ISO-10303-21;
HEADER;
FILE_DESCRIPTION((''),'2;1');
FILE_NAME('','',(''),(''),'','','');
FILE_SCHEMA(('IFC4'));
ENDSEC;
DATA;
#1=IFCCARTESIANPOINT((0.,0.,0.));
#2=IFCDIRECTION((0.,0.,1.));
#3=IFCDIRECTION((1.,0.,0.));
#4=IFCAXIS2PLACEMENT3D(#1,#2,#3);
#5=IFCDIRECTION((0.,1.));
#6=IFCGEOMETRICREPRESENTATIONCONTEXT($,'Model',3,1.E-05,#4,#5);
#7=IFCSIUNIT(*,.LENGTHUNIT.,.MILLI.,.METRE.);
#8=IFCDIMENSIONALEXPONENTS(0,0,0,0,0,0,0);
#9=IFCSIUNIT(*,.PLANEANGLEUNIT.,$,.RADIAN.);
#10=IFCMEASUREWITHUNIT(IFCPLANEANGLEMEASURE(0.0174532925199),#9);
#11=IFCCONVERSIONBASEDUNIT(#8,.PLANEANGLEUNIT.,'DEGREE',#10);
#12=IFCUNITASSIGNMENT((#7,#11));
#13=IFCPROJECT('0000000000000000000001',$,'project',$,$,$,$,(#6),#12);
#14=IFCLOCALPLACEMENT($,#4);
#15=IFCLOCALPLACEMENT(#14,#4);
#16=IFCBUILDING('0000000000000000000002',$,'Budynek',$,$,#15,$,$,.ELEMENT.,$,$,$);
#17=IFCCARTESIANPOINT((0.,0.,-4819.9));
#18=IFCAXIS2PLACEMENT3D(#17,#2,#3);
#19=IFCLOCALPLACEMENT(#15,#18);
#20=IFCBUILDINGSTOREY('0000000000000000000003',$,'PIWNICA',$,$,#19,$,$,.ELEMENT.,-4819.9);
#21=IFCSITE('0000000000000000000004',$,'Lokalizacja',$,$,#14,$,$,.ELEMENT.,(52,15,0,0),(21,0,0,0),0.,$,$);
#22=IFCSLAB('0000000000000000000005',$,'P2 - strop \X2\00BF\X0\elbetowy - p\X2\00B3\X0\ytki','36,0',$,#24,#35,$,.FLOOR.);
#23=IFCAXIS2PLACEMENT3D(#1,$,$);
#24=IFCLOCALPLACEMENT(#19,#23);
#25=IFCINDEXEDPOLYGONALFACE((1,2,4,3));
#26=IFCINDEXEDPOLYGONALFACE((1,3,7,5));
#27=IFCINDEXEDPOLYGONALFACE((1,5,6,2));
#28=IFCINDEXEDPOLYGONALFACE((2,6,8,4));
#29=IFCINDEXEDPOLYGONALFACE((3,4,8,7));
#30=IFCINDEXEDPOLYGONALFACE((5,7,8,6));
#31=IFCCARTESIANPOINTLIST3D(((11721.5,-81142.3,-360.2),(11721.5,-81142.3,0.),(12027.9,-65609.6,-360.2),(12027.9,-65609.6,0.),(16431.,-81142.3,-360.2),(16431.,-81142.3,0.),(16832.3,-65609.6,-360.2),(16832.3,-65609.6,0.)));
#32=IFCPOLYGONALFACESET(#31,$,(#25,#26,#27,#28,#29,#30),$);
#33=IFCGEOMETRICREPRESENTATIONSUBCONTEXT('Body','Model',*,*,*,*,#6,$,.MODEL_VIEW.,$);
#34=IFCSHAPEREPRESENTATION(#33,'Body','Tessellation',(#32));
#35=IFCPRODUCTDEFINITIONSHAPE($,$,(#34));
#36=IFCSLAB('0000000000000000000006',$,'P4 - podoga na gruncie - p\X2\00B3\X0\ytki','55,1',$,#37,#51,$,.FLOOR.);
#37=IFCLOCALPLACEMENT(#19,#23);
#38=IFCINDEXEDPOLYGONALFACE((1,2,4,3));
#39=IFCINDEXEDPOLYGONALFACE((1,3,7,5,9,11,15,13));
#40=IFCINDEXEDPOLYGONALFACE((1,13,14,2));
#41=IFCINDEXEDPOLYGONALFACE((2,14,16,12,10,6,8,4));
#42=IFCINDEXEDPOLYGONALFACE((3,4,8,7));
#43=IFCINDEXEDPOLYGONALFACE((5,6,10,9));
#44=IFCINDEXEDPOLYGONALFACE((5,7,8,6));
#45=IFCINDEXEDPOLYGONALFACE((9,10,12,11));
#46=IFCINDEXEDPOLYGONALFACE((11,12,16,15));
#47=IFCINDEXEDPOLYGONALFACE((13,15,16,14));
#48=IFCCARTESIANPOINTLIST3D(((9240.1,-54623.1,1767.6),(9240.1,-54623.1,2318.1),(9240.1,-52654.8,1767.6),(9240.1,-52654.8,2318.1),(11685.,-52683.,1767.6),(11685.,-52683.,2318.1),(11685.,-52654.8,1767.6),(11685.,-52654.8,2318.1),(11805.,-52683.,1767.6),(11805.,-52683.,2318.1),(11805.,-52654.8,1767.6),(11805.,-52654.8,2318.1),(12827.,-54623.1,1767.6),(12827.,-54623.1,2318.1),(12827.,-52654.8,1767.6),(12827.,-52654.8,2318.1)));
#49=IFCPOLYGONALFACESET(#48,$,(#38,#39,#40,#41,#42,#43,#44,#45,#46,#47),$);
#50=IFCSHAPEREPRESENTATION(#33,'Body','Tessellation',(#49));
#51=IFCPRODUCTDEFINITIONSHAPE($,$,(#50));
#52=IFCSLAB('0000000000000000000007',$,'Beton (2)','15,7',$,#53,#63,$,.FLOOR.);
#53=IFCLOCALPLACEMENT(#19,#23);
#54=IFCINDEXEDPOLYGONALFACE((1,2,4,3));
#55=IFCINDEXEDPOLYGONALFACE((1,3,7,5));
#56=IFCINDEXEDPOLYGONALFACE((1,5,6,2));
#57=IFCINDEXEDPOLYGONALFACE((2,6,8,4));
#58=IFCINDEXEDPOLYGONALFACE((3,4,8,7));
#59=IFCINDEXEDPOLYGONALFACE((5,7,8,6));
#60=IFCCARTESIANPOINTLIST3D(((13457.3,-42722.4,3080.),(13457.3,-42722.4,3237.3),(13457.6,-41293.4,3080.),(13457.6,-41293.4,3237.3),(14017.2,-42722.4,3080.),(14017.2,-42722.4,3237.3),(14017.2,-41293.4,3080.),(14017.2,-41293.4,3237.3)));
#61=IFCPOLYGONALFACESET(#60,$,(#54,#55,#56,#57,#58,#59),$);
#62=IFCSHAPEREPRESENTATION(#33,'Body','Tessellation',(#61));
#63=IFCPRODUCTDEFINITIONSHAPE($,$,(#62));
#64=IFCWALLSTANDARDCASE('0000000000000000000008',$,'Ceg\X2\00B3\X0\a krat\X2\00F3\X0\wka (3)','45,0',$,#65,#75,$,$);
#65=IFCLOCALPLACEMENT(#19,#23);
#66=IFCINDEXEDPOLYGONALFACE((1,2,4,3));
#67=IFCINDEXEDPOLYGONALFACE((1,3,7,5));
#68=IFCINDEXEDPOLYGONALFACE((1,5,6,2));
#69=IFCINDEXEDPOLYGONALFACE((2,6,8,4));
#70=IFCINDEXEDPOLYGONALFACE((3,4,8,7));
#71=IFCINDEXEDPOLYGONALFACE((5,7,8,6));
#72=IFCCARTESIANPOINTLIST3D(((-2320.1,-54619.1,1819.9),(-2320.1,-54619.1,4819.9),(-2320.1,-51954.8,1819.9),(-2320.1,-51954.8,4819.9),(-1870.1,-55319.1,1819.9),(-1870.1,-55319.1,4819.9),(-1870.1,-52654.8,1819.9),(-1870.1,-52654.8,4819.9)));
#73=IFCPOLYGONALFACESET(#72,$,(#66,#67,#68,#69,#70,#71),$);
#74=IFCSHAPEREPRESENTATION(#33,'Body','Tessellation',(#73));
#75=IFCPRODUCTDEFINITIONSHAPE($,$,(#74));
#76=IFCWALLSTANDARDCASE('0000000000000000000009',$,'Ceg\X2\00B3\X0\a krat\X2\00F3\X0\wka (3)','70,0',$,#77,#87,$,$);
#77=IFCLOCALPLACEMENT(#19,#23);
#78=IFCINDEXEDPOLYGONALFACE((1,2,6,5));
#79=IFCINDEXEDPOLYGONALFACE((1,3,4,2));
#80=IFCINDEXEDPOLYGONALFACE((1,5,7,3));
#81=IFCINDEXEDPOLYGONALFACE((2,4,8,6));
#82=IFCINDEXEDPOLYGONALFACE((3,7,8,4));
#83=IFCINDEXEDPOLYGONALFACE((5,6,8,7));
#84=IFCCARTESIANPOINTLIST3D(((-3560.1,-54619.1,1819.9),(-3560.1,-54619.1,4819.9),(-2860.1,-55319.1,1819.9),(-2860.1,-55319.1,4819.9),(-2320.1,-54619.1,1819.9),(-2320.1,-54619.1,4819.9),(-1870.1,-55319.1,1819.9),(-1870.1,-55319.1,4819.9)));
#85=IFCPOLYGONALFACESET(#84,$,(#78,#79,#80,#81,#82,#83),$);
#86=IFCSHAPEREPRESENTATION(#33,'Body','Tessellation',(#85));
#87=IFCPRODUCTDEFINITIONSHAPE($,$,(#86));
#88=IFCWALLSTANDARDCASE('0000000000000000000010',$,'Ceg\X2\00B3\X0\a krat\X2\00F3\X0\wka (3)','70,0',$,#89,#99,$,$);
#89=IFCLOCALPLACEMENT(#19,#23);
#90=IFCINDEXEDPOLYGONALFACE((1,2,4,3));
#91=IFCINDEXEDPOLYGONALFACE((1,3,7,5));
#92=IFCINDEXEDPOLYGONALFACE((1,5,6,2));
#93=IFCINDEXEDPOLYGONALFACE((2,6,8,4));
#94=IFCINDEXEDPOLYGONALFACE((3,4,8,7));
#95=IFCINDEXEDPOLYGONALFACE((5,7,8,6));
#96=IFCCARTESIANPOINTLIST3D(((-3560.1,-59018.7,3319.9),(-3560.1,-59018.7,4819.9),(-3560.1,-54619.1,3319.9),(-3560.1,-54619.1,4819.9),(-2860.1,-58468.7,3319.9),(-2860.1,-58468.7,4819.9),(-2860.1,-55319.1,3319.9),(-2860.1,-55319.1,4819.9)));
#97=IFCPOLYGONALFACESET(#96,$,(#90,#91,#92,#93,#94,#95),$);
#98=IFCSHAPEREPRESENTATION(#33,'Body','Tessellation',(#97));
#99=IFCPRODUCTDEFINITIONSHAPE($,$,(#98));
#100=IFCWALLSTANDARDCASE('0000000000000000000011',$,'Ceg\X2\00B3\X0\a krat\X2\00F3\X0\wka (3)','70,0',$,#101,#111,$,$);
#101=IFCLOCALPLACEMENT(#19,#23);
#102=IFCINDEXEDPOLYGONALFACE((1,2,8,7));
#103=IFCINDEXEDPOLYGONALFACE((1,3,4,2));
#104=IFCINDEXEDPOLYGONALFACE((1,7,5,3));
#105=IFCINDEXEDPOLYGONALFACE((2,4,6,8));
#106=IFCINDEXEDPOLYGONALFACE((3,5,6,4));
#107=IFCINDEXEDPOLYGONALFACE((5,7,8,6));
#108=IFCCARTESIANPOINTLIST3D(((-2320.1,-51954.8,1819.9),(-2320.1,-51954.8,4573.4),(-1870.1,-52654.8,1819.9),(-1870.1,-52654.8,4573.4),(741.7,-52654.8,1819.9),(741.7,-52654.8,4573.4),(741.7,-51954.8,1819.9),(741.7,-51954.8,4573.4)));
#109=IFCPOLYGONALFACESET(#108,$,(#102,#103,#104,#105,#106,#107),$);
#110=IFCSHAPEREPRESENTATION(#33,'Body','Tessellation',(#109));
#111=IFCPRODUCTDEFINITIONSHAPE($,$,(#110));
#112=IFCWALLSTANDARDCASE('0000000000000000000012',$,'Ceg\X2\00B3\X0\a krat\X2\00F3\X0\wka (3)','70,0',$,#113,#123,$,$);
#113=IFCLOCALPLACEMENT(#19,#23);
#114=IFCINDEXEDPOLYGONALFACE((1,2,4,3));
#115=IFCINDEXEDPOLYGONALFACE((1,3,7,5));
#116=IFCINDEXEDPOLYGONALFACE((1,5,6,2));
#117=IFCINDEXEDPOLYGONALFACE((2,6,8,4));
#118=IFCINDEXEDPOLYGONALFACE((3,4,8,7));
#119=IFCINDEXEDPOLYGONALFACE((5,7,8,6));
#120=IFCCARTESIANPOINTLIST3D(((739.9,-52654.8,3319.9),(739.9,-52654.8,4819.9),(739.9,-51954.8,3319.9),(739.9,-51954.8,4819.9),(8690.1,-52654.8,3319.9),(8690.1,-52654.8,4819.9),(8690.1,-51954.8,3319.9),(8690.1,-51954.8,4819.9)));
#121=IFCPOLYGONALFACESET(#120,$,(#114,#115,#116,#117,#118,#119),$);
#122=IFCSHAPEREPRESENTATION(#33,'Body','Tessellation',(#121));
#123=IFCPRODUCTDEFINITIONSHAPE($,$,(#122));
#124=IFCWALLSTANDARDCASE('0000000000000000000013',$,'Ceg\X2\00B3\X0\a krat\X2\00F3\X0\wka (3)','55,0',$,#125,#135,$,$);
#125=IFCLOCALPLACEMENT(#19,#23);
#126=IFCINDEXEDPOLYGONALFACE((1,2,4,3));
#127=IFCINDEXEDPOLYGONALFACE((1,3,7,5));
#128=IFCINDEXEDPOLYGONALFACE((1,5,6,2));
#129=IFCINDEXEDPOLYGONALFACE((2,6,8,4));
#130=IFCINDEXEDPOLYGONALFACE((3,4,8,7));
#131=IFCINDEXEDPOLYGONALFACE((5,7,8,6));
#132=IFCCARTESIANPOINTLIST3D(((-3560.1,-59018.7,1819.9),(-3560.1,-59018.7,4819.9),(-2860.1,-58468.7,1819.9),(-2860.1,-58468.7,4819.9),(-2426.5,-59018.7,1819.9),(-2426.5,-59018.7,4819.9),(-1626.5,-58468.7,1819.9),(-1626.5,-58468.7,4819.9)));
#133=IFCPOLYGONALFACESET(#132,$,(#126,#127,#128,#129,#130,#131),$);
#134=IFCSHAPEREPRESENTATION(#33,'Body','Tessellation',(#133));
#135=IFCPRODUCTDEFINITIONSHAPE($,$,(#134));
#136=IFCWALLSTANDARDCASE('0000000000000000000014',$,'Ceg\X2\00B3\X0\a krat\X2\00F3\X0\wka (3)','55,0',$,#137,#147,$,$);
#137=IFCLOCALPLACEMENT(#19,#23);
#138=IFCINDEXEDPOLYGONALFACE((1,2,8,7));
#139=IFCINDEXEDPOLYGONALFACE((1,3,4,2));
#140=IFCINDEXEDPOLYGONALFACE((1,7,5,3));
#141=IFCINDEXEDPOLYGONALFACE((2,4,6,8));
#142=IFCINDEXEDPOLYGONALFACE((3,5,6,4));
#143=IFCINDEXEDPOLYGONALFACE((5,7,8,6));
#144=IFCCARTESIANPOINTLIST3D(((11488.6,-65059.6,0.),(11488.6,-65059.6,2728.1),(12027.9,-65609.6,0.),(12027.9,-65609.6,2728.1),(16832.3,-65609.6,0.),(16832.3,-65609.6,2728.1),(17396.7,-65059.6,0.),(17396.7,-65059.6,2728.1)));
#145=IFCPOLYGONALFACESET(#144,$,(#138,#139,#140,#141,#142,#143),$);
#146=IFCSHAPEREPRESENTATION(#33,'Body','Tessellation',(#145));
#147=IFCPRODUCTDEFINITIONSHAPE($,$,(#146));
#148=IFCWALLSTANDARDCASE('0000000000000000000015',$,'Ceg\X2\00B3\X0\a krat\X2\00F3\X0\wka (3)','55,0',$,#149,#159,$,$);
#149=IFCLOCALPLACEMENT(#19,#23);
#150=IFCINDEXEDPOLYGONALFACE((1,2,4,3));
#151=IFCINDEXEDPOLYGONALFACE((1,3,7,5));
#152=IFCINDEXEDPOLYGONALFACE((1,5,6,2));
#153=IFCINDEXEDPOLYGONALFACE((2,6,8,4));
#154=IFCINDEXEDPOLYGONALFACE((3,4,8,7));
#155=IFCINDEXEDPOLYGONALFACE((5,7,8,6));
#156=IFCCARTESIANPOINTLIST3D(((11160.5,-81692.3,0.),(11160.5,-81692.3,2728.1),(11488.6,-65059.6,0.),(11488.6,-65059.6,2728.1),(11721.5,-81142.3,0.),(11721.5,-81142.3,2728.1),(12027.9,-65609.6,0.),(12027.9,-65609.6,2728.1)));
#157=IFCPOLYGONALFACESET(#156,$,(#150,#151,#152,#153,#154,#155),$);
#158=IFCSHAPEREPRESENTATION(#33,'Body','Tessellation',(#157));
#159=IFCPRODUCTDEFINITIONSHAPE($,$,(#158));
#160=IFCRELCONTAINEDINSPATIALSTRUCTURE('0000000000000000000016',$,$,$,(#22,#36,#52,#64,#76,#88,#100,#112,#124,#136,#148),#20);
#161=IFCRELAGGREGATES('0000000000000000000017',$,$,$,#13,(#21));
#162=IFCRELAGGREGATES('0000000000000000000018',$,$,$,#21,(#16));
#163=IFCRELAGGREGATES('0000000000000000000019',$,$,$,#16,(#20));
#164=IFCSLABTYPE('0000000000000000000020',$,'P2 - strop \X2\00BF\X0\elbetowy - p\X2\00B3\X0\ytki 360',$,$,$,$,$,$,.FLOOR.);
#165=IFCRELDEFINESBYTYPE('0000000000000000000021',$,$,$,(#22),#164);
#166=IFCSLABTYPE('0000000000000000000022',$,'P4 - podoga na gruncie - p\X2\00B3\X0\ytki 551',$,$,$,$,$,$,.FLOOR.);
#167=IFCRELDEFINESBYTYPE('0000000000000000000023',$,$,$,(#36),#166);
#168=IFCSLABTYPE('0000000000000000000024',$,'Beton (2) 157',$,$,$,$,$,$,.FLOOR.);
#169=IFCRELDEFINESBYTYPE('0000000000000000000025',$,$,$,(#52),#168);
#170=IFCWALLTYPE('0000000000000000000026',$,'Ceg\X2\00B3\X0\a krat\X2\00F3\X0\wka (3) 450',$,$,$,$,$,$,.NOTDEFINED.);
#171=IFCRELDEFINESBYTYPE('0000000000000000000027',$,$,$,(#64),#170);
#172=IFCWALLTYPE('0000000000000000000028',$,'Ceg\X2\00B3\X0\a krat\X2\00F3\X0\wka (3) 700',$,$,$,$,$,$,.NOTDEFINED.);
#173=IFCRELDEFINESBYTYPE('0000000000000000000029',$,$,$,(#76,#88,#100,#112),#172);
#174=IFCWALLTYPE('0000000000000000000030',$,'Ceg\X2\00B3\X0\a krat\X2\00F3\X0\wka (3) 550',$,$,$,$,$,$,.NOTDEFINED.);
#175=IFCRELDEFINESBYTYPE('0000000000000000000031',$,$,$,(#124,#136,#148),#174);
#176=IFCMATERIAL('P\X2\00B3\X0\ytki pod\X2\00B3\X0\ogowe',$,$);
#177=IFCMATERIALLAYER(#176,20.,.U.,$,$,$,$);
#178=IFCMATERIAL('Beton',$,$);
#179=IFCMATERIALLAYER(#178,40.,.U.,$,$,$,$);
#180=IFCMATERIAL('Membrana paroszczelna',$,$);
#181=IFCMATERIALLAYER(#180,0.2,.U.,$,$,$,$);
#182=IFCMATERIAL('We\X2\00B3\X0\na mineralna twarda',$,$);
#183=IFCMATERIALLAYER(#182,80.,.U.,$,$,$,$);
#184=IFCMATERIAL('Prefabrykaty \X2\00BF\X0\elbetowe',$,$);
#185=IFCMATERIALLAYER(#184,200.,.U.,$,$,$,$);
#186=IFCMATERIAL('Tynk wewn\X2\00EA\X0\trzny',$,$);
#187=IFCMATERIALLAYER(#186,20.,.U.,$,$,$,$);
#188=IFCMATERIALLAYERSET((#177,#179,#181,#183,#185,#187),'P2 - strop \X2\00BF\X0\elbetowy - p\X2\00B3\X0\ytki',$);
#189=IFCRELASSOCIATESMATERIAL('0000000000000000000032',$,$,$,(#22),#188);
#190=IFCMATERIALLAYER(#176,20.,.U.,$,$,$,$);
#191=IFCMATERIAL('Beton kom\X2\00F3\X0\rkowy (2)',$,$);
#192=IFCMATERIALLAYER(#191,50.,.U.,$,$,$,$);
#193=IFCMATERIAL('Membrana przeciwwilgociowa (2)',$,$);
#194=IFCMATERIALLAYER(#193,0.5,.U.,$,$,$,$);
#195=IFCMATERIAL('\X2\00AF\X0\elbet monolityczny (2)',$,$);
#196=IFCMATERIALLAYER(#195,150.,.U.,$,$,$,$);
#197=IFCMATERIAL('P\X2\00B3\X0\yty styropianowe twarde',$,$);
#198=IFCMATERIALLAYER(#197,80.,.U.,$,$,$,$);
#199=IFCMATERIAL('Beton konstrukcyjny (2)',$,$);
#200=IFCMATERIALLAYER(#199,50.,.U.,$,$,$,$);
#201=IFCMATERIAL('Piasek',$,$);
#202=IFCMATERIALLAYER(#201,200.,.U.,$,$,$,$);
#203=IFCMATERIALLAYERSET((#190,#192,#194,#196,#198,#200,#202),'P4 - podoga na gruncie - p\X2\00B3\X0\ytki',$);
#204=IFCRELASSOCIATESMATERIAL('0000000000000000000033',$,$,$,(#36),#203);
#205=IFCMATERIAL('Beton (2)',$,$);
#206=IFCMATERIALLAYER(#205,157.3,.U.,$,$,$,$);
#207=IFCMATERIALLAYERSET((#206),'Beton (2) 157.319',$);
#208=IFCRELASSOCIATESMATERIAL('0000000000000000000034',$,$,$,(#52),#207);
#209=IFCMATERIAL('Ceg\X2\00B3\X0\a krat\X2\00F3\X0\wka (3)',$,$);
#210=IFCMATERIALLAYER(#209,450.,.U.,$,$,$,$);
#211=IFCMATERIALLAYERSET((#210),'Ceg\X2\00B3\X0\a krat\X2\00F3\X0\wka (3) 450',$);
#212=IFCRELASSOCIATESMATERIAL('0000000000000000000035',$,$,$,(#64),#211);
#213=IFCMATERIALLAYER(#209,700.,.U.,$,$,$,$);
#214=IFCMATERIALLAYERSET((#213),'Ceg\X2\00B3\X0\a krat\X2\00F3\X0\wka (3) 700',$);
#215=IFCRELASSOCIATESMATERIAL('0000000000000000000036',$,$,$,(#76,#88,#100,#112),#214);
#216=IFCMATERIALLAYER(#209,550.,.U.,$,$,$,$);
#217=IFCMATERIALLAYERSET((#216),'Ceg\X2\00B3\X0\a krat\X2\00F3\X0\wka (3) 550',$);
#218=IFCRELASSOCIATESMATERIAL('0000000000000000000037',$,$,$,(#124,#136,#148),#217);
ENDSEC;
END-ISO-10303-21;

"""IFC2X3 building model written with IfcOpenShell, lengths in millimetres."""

from ifc_helpers import new_model, entity, si_unit, converted_unit, direction, frame, origin_with_axes, place, context, subcontext, project, spatial, polyline, outline, extrude, material, layer, layer_set, layer_usage, type_object, element, save


model = new_model("IFC2X3")

# Units and contexts
model_context = context("Model", 3, precision=1e-05, world=origin_with_axes(), true_north=direction((0.0, 1.0)))
body_context = subcontext(model_context, "Body", "Model", "MODEL_VIEW")
ifc_project = project(units=[si_unit("LENGTHUNIT", "METRE", prefix="MILLI"), converted_unit("PLANEANGLEUNIT", "DEGREE", entity("IfcPlaneAngleMeasure", 0.0174532925199), si_unit("PLANEANGLEUNIT", "RADIAN"), dimensions=[0, 0, 0, 0, 0, 0, 0])], contexts=[model_context])

# Site, building, storey
site_placement = place(None, origin_with_axes())
site = spatial("IfcSite", under=ifc_project, at=site_placement, Name="Lokalizacja", CompositionType="ELEMENT", RefLatitude=(52, 15, 0, 0), RefLongitude=(21, 0, 0, 0), RefElevation=0.0)
building_placement = place(site_placement, origin_with_axes())
building = spatial("IfcBuilding", under=site, at=building_placement, Name="Budynek", CompositionType="ELEMENT")
storey_placement = place(building_placement, frame((0.0, 0.0, -4819.9), z_axis=(0.0, 0.0, 1.0), x_axis=(1.0, 0.0, 0.0)))
storey = spatial("IfcBuildingStorey", under=building, at=storey_placement, Name="PIWNICA", CompositionType="ELEMENT", Elevation=-4819.9)

# Slabs
ifc_material_1 = material(Name="P³ytki pod³ogowe")
ifc_layer_1 = layer(ifc_material_1, 20.0, ventilated="UNKNOWN")
ifc_material_2 = material(Name="Beton")
ifc_layer_2 = layer(ifc_material_2, 40.0, ventilated="UNKNOWN")
ifc_material_3 = material(Name="Membrana paroszczelna")
ifc_layer_3 = layer(ifc_material_3, 0.2, ventilated="UNKNOWN")
ifc_material_4 = material(Name="We³na mineralna twarda")
ifc_layer_4 = layer(ifc_material_4, 80.0, ventilated="UNKNOWN")
ifc_material_5 = material(Name="Prefabrykaty ¿elbetowe")
ifc_layer_5 = layer(ifc_material_5, 200.0, ventilated="UNKNOWN")
ifc_material_6 = material(Name="Tynk wewnêtrzny")
ifc_layer_6 = layer(ifc_material_6, 20.0, ventilated="UNKNOWN")
ifc_layer_set_1 = layer_set([ifc_layer_1, ifc_layer_2, ifc_layer_3, ifc_layer_4, ifc_layer_5, ifc_layer_6], Name="P2 - strop ¿elbetowy - p³ytki")
ifc_layer_usage_1 = layer_usage(ifc_layer_set_1, "AXIS3", "NEGATIVE", 360.2)
slab_type_1 = type_object("IfcSlabType", Name="P2 - strop ¿elbetowy - p³ytki 360", PredefinedType="FLOOR")
slab_1_placement = place(storey_placement, frame((12027.9, -65609.6, 0.0), z_axis=(0.0, 0.0, 1.0), x_axis=(1.0, 0.0, 0.0)))
element("IfcSlab", 1, at=slab_1_placement, inside=storey, type_object=slab_type_1, material=ifc_layer_usage_1, Name="P2 - strop ¿elbetowy - p³ytki", Description="36,0", PredefinedType="FLOOR", context=body_context, shape_type="SweptSolid", body=[
    extrude(outline(polyline([(0.0, 0.0), (-306.4, -15532.7), (4403.1, -15532.7), (4804.4, 0.0), (0.0, 0.0)])), frame((0.0, 0.0, -360.2), z_axis=(0.0, 0.0, 1.0), x_axis=(1.0, 0.0, 0.0)), (0.0, 0.0, 1.0), 360.2),
])
ifc_layer_7 = layer(ifc_material_1, 20.0, ventilated="UNKNOWN")
ifc_material_7 = material(Name="Beton komórkowy (2)")
ifc_layer_8 = layer(ifc_material_7, 50.0, ventilated="UNKNOWN")
ifc_material_8 = material(Name="Membrana przeciwwilgociowa (2)")
ifc_layer_9 = layer(ifc_material_8, 0.5, ventilated="UNKNOWN")
ifc_material_9 = material(Name="¯elbet monolityczny (2)")
ifc_layer_10 = layer(ifc_material_9, 150.0, ventilated="UNKNOWN")
ifc_material_10 = material(Name="P³yty styropianowe twarde")
ifc_layer_11 = layer(ifc_material_10, 80.0, ventilated="UNKNOWN")
ifc_material_11 = material(Name="Beton konstrukcyjny (2)")
ifc_layer_12 = layer(ifc_material_11, 50.0, ventilated="UNKNOWN")
ifc_material_12 = material(Name="Piasek")
ifc_layer_13 = layer(ifc_material_12, 200.0, ventilated="UNKNOWN")
ifc_layer_set_2 = layer_set([ifc_layer_7, ifc_layer_8, ifc_layer_9, ifc_layer_10, ifc_layer_11, ifc_layer_12, ifc_layer_13], Name="P4 - podoga na gruncie - p³ytki")
ifc_layer_usage_2 = layer_usage(ifc_layer_set_2, "AXIS3", "NEGATIVE", 550.5)
slab_type_2 = type_object("IfcSlabType", Name="P4 - podoga na gruncie - p³ytki 551", PredefinedType="FLOOR")
slab_2_placement = place(storey_placement, frame((9240.1, -52654.8, 2318.1), z_axis=(0.0, 0.0, 1.0), x_axis=(1.0, 0.0, 0.0)))
element("IfcSlab", 2, at=slab_2_placement, inside=storey, type_object=slab_type_2, material=ifc_layer_usage_2, Name="P4 - podoga na gruncie - p³ytki", Description="55,1", PredefinedType="FLOOR", context=body_context, shape_type="SweptSolid", body=[
    extrude(outline(polyline([(0.0, 0.0), (0.0, -1968.3), (3586.9, -1968.3), (3586.9, 0.0), (2564.9, 0.0), (2564.9, -28.2), (2444.9, -28.2), (2444.9, 0.0), (0.0, 0.0)])), frame((0.0, 0.0, -550.5), z_axis=(0.0, 0.0, 1.0), x_axis=(1.0, 0.0, 0.0)), (0.0, 0.0, 1.0), 550.5),
])
ifc_material_13 = material(Name="Beton (2)")
ifc_layer_14 = layer(ifc_material_13, 157.3, ventilated="UNKNOWN")
ifc_layer_set_3 = layer_set([ifc_layer_14], Name="Beton (2) 157.319")
ifc_layer_usage_3 = layer_usage(ifc_layer_set_3, "AXIS3", "NEGATIVE", 157.3)
slab_type_3 = type_object("IfcSlabType", Name="Beton (2) 157", PredefinedType="FLOOR")
slab_3_placement = place(storey_placement, frame((13457.6, -41293.4, 3237.3), z_axis=(0.0, 0.0, 1.0), x_axis=(1.0, 0.0, 0.0)))
element("IfcSlab", 3, at=slab_3_placement, inside=storey, type_object=slab_type_3, material=ifc_layer_usage_3, Name="Beton (2)", Description="15,7", PredefinedType="FLOOR", context=body_context, shape_type="SweptSolid", body=[
    extrude(outline(polyline([(0.0, 0.0), (-0.3, -1429.0), (559.6, -1429.0), (559.6, 0.0), (0.0, 0.0)])), frame((0.0, 0.0, -157.3), z_axis=(0.0, 0.0, 1.0), x_axis=(1.0, 0.0, 0.0)), (0.0, 0.0, 1.0), 157.3),
])

# Walls
ifc_material_14 = material(Name="Ceg³a kratówka (3)")
ifc_layer_15 = layer(ifc_material_14, 450.0, ventilated="UNKNOWN")
ifc_layer_set_4 = layer_set([ifc_layer_15], Name="Ceg³a kratówka (3) 450")
ifc_layer_usage_4 = layer_usage(ifc_layer_set_4, "AXIS2", "POSITIVE", 0.0)
wall_type_1 = type_object("IfcWallType", Name="Ceg³a kratówka (3) 450", PredefinedType="NOTDEFINED")
wall_1_placement = place(storey_placement, frame((-1870.1, -55319.1, 1819.9), z_axis=(0.0, 0.0, 1.0), x_axis=(0.0, 1.0, 0.0)))
element("IfcWallStandardCase", 4, at=wall_1_placement, inside=storey, type_object=wall_type_1, material=ifc_layer_usage_4, Name="Ceg³a kratówka (3)", Description="45,0", context=body_context, shape_type="SweptSolid", body=[
    extrude(outline(polyline([(0.0, 0.0), (2664.2, 0.0), (3364.2, 450.0), (700.0, 450.0), (0.0, 0.0)])), origin_with_axes(), (0.0, 0.0, 1.0), 3000.0),
])
ifc_layer_16 = layer(ifc_material_14, 700.0, ventilated="UNKNOWN")
ifc_layer_set_5 = layer_set([ifc_layer_16], Name="Ceg³a kratówka (3) 700")
ifc_layer_usage_5 = layer_usage(ifc_layer_set_5, "AXIS2", "POSITIVE", 0.0)
wall_type_2 = type_object("IfcWallType", Name="Ceg³a kratówka (3) 700", PredefinedType="NOTDEFINED")
wall_2_placement = place(storey_placement, frame((-2860.1, -55319.1, 1819.9), z_axis=(0.0, 0.0, 1.0), x_axis=(1.0, 0.0, 0.0)))
element("IfcWallStandardCase", 5, at=wall_2_placement, inside=storey, type_object=wall_type_2, material=ifc_layer_usage_5, Name="Ceg³a kratówka (3)", Description="70,0", context=body_context, shape_type="SweptSolid", body=[
    extrude(outline(polyline([(0.0, 0.0), (990.0, 0.0), (540.0, 700.0), (-700.0, 700.0), (0.0, 0.0)])), origin_with_axes(), (0.0, 0.0, 1.0), 3000.0),
])
ifc_layer_usage_6 = layer_usage(ifc_layer_set_5, "AXIS2", "POSITIVE", 0.0)
wall_3_placement = place(storey_placement, frame((-2860.1, -58468.7, 3319.9), z_axis=(0.0, 0.0, 1.0), x_axis=(0.0, 1.0, 0.0)))
element("IfcWallStandardCase", 6, at=wall_3_placement, inside=storey, type_object=wall_type_2, material=ifc_layer_usage_6, Name="Ceg³a kratówka (3)", Description="70,0", context=body_context, shape_type="SweptSolid", body=[
    extrude(outline(polyline([(0.0, 0.0), (3149.7, 0.0), (3849.7, 700.0), (-550.0, 700.0), (0.0, 0.0)])), origin_with_axes(), (0.0, 0.0, 1.0), 1500.0),
])
ifc_layer_usage_7 = layer_usage(ifc_layer_set_5, "AXIS2", "POSITIVE", 0.0)
wall_4_placement = place(storey_placement, frame((-1870.1, -52654.8, 1819.9), z_axis=(0.0, 0.0, 1.0), x_axis=(1.0, 0.0, 0.0)))
element("IfcWallStandardCase", 7, at=wall_4_placement, inside=storey, type_object=wall_type_2, material=ifc_layer_usage_7, Name="Ceg³a kratówka (3)", Description="70,0", context=body_context, shape_type="SweptSolid", body=[
    extrude(outline(polyline([(0.0, 0.0), (2611.8, 0.0), (2611.8, 700.0), (-450.0, 700.0), (0.0, 0.0)])), origin_with_axes(), (0.0, 0.0, 1.0), 2753.5),
])

# Walls
ifc_layer_usage_8 = layer_usage(ifc_layer_set_5, "AXIS2", "NEGATIVE", 0.0)
wall_5_placement = place(storey_placement, frame((8690.1, -52654.8, 3319.9), z_axis=(0.0, 0.0, 1.0), x_axis=(-1.0, 0.0, 0.0)))
element("IfcWallStandardCase", 8, at=wall_5_placement, inside=storey, type_object=wall_type_2, material=ifc_layer_usage_8, Name="Ceg³a kratówka (3)", Description="70,0", context=body_context, shape_type="SweptSolid", body=[
    extrude(outline(polyline([(0.0, -700.0), (7950.2, -700.0), (7950.2, 0.0), (0.0, 0.0), (0.0, -700.0)])), origin_with_axes(), (0.0, 0.0, 1.0), 1500.0),
])
ifc_layer_17 = layer(ifc_material_14, 550.0, ventilated="UNKNOWN")
ifc_layer_set_6 = layer_set([ifc_layer_17], Name="Ceg³a kratówka (3) 550")
ifc_layer_usage_9 = layer_usage(ifc_layer_set_6, "AXIS2", "POSITIVE", 0.0)
wall_type_3 = type_object("IfcWallType", Name="Ceg³a kratówka (3) 550", PredefinedType="NOTDEFINED")
wall_6_placement = place(storey_placement, frame((-1626.5, -58468.7, 1819.9), z_axis=(0.0, 0.0, 1.0), x_axis=(-1.0, 0.0, 0.0)))
element("IfcWallStandardCase", 9, at=wall_6_placement, inside=storey, type_object=wall_type_3, material=ifc_layer_usage_9, Name="Ceg³a kratówka (3)", Description="55,0", context=body_context, shape_type="SweptSolid", body=[
    extrude(outline(polyline([(0.0, 0.0), (1233.6, 0.0), (1933.6, 550.0), (800.0, 550.0), (0.0, 0.0)])), origin_with_axes(), (0.0, 0.0, 1.0), 3000.0),
])
ifc_layer_usage_10 = layer_usage(ifc_layer_set_6, "AXIS2", "POSITIVE", 0.0)
wall_7_placement = place(storey_placement, frame((12027.9, -65609.6, 0.0), z_axis=(0.0, 0.0, 1.0), x_axis=(1.0, 0.0, 0.0)))
element("IfcWallStandardCase", 10, at=wall_7_placement, inside=storey, type_object=wall_type_3, material=ifc_layer_usage_10, Name="Ceg³a kratówka (3)", Description="55,0", context=body_context, shape_type="SweptSolid", body=[
    extrude(outline(polyline([(0.0, 0.0), (4804.4, 0.0), (5368.8, 550.0), (-539.3, 550.0), (0.0, 0.0)])), origin_with_axes(), (0.0, 0.0, 1.0), 2728.1),
])
ifc_layer_usage_11 = layer_usage(ifc_layer_set_6, "AXIS2", "POSITIVE", 0.0)
wall_8_placement = place(storey_placement, frame((11721.5, -81142.3, 0.0), z_axis=(0.0, 0.0, 1.0), x_axis=(0.019722, 0.999805, 0.0)))
element("IfcWallStandardCase", 11, at=wall_8_placement, inside=storey, type_object=wall_type_3, material=ifc_layer_usage_11, Name="Ceg³a kratówka (3)", Description="55,0", context=body_context, shape_type="SweptSolid", body=[
    extrude(outline(polyline([(0.0, 0.0), (15535.7, 0.0), (16075.0, 550.0), (-561.0, 550.0), (0.0, 0.0)])), origin_with_axes(), (0.0, 0.0, 1.0), 2728.1),
])

save(model, "model.ifc")
